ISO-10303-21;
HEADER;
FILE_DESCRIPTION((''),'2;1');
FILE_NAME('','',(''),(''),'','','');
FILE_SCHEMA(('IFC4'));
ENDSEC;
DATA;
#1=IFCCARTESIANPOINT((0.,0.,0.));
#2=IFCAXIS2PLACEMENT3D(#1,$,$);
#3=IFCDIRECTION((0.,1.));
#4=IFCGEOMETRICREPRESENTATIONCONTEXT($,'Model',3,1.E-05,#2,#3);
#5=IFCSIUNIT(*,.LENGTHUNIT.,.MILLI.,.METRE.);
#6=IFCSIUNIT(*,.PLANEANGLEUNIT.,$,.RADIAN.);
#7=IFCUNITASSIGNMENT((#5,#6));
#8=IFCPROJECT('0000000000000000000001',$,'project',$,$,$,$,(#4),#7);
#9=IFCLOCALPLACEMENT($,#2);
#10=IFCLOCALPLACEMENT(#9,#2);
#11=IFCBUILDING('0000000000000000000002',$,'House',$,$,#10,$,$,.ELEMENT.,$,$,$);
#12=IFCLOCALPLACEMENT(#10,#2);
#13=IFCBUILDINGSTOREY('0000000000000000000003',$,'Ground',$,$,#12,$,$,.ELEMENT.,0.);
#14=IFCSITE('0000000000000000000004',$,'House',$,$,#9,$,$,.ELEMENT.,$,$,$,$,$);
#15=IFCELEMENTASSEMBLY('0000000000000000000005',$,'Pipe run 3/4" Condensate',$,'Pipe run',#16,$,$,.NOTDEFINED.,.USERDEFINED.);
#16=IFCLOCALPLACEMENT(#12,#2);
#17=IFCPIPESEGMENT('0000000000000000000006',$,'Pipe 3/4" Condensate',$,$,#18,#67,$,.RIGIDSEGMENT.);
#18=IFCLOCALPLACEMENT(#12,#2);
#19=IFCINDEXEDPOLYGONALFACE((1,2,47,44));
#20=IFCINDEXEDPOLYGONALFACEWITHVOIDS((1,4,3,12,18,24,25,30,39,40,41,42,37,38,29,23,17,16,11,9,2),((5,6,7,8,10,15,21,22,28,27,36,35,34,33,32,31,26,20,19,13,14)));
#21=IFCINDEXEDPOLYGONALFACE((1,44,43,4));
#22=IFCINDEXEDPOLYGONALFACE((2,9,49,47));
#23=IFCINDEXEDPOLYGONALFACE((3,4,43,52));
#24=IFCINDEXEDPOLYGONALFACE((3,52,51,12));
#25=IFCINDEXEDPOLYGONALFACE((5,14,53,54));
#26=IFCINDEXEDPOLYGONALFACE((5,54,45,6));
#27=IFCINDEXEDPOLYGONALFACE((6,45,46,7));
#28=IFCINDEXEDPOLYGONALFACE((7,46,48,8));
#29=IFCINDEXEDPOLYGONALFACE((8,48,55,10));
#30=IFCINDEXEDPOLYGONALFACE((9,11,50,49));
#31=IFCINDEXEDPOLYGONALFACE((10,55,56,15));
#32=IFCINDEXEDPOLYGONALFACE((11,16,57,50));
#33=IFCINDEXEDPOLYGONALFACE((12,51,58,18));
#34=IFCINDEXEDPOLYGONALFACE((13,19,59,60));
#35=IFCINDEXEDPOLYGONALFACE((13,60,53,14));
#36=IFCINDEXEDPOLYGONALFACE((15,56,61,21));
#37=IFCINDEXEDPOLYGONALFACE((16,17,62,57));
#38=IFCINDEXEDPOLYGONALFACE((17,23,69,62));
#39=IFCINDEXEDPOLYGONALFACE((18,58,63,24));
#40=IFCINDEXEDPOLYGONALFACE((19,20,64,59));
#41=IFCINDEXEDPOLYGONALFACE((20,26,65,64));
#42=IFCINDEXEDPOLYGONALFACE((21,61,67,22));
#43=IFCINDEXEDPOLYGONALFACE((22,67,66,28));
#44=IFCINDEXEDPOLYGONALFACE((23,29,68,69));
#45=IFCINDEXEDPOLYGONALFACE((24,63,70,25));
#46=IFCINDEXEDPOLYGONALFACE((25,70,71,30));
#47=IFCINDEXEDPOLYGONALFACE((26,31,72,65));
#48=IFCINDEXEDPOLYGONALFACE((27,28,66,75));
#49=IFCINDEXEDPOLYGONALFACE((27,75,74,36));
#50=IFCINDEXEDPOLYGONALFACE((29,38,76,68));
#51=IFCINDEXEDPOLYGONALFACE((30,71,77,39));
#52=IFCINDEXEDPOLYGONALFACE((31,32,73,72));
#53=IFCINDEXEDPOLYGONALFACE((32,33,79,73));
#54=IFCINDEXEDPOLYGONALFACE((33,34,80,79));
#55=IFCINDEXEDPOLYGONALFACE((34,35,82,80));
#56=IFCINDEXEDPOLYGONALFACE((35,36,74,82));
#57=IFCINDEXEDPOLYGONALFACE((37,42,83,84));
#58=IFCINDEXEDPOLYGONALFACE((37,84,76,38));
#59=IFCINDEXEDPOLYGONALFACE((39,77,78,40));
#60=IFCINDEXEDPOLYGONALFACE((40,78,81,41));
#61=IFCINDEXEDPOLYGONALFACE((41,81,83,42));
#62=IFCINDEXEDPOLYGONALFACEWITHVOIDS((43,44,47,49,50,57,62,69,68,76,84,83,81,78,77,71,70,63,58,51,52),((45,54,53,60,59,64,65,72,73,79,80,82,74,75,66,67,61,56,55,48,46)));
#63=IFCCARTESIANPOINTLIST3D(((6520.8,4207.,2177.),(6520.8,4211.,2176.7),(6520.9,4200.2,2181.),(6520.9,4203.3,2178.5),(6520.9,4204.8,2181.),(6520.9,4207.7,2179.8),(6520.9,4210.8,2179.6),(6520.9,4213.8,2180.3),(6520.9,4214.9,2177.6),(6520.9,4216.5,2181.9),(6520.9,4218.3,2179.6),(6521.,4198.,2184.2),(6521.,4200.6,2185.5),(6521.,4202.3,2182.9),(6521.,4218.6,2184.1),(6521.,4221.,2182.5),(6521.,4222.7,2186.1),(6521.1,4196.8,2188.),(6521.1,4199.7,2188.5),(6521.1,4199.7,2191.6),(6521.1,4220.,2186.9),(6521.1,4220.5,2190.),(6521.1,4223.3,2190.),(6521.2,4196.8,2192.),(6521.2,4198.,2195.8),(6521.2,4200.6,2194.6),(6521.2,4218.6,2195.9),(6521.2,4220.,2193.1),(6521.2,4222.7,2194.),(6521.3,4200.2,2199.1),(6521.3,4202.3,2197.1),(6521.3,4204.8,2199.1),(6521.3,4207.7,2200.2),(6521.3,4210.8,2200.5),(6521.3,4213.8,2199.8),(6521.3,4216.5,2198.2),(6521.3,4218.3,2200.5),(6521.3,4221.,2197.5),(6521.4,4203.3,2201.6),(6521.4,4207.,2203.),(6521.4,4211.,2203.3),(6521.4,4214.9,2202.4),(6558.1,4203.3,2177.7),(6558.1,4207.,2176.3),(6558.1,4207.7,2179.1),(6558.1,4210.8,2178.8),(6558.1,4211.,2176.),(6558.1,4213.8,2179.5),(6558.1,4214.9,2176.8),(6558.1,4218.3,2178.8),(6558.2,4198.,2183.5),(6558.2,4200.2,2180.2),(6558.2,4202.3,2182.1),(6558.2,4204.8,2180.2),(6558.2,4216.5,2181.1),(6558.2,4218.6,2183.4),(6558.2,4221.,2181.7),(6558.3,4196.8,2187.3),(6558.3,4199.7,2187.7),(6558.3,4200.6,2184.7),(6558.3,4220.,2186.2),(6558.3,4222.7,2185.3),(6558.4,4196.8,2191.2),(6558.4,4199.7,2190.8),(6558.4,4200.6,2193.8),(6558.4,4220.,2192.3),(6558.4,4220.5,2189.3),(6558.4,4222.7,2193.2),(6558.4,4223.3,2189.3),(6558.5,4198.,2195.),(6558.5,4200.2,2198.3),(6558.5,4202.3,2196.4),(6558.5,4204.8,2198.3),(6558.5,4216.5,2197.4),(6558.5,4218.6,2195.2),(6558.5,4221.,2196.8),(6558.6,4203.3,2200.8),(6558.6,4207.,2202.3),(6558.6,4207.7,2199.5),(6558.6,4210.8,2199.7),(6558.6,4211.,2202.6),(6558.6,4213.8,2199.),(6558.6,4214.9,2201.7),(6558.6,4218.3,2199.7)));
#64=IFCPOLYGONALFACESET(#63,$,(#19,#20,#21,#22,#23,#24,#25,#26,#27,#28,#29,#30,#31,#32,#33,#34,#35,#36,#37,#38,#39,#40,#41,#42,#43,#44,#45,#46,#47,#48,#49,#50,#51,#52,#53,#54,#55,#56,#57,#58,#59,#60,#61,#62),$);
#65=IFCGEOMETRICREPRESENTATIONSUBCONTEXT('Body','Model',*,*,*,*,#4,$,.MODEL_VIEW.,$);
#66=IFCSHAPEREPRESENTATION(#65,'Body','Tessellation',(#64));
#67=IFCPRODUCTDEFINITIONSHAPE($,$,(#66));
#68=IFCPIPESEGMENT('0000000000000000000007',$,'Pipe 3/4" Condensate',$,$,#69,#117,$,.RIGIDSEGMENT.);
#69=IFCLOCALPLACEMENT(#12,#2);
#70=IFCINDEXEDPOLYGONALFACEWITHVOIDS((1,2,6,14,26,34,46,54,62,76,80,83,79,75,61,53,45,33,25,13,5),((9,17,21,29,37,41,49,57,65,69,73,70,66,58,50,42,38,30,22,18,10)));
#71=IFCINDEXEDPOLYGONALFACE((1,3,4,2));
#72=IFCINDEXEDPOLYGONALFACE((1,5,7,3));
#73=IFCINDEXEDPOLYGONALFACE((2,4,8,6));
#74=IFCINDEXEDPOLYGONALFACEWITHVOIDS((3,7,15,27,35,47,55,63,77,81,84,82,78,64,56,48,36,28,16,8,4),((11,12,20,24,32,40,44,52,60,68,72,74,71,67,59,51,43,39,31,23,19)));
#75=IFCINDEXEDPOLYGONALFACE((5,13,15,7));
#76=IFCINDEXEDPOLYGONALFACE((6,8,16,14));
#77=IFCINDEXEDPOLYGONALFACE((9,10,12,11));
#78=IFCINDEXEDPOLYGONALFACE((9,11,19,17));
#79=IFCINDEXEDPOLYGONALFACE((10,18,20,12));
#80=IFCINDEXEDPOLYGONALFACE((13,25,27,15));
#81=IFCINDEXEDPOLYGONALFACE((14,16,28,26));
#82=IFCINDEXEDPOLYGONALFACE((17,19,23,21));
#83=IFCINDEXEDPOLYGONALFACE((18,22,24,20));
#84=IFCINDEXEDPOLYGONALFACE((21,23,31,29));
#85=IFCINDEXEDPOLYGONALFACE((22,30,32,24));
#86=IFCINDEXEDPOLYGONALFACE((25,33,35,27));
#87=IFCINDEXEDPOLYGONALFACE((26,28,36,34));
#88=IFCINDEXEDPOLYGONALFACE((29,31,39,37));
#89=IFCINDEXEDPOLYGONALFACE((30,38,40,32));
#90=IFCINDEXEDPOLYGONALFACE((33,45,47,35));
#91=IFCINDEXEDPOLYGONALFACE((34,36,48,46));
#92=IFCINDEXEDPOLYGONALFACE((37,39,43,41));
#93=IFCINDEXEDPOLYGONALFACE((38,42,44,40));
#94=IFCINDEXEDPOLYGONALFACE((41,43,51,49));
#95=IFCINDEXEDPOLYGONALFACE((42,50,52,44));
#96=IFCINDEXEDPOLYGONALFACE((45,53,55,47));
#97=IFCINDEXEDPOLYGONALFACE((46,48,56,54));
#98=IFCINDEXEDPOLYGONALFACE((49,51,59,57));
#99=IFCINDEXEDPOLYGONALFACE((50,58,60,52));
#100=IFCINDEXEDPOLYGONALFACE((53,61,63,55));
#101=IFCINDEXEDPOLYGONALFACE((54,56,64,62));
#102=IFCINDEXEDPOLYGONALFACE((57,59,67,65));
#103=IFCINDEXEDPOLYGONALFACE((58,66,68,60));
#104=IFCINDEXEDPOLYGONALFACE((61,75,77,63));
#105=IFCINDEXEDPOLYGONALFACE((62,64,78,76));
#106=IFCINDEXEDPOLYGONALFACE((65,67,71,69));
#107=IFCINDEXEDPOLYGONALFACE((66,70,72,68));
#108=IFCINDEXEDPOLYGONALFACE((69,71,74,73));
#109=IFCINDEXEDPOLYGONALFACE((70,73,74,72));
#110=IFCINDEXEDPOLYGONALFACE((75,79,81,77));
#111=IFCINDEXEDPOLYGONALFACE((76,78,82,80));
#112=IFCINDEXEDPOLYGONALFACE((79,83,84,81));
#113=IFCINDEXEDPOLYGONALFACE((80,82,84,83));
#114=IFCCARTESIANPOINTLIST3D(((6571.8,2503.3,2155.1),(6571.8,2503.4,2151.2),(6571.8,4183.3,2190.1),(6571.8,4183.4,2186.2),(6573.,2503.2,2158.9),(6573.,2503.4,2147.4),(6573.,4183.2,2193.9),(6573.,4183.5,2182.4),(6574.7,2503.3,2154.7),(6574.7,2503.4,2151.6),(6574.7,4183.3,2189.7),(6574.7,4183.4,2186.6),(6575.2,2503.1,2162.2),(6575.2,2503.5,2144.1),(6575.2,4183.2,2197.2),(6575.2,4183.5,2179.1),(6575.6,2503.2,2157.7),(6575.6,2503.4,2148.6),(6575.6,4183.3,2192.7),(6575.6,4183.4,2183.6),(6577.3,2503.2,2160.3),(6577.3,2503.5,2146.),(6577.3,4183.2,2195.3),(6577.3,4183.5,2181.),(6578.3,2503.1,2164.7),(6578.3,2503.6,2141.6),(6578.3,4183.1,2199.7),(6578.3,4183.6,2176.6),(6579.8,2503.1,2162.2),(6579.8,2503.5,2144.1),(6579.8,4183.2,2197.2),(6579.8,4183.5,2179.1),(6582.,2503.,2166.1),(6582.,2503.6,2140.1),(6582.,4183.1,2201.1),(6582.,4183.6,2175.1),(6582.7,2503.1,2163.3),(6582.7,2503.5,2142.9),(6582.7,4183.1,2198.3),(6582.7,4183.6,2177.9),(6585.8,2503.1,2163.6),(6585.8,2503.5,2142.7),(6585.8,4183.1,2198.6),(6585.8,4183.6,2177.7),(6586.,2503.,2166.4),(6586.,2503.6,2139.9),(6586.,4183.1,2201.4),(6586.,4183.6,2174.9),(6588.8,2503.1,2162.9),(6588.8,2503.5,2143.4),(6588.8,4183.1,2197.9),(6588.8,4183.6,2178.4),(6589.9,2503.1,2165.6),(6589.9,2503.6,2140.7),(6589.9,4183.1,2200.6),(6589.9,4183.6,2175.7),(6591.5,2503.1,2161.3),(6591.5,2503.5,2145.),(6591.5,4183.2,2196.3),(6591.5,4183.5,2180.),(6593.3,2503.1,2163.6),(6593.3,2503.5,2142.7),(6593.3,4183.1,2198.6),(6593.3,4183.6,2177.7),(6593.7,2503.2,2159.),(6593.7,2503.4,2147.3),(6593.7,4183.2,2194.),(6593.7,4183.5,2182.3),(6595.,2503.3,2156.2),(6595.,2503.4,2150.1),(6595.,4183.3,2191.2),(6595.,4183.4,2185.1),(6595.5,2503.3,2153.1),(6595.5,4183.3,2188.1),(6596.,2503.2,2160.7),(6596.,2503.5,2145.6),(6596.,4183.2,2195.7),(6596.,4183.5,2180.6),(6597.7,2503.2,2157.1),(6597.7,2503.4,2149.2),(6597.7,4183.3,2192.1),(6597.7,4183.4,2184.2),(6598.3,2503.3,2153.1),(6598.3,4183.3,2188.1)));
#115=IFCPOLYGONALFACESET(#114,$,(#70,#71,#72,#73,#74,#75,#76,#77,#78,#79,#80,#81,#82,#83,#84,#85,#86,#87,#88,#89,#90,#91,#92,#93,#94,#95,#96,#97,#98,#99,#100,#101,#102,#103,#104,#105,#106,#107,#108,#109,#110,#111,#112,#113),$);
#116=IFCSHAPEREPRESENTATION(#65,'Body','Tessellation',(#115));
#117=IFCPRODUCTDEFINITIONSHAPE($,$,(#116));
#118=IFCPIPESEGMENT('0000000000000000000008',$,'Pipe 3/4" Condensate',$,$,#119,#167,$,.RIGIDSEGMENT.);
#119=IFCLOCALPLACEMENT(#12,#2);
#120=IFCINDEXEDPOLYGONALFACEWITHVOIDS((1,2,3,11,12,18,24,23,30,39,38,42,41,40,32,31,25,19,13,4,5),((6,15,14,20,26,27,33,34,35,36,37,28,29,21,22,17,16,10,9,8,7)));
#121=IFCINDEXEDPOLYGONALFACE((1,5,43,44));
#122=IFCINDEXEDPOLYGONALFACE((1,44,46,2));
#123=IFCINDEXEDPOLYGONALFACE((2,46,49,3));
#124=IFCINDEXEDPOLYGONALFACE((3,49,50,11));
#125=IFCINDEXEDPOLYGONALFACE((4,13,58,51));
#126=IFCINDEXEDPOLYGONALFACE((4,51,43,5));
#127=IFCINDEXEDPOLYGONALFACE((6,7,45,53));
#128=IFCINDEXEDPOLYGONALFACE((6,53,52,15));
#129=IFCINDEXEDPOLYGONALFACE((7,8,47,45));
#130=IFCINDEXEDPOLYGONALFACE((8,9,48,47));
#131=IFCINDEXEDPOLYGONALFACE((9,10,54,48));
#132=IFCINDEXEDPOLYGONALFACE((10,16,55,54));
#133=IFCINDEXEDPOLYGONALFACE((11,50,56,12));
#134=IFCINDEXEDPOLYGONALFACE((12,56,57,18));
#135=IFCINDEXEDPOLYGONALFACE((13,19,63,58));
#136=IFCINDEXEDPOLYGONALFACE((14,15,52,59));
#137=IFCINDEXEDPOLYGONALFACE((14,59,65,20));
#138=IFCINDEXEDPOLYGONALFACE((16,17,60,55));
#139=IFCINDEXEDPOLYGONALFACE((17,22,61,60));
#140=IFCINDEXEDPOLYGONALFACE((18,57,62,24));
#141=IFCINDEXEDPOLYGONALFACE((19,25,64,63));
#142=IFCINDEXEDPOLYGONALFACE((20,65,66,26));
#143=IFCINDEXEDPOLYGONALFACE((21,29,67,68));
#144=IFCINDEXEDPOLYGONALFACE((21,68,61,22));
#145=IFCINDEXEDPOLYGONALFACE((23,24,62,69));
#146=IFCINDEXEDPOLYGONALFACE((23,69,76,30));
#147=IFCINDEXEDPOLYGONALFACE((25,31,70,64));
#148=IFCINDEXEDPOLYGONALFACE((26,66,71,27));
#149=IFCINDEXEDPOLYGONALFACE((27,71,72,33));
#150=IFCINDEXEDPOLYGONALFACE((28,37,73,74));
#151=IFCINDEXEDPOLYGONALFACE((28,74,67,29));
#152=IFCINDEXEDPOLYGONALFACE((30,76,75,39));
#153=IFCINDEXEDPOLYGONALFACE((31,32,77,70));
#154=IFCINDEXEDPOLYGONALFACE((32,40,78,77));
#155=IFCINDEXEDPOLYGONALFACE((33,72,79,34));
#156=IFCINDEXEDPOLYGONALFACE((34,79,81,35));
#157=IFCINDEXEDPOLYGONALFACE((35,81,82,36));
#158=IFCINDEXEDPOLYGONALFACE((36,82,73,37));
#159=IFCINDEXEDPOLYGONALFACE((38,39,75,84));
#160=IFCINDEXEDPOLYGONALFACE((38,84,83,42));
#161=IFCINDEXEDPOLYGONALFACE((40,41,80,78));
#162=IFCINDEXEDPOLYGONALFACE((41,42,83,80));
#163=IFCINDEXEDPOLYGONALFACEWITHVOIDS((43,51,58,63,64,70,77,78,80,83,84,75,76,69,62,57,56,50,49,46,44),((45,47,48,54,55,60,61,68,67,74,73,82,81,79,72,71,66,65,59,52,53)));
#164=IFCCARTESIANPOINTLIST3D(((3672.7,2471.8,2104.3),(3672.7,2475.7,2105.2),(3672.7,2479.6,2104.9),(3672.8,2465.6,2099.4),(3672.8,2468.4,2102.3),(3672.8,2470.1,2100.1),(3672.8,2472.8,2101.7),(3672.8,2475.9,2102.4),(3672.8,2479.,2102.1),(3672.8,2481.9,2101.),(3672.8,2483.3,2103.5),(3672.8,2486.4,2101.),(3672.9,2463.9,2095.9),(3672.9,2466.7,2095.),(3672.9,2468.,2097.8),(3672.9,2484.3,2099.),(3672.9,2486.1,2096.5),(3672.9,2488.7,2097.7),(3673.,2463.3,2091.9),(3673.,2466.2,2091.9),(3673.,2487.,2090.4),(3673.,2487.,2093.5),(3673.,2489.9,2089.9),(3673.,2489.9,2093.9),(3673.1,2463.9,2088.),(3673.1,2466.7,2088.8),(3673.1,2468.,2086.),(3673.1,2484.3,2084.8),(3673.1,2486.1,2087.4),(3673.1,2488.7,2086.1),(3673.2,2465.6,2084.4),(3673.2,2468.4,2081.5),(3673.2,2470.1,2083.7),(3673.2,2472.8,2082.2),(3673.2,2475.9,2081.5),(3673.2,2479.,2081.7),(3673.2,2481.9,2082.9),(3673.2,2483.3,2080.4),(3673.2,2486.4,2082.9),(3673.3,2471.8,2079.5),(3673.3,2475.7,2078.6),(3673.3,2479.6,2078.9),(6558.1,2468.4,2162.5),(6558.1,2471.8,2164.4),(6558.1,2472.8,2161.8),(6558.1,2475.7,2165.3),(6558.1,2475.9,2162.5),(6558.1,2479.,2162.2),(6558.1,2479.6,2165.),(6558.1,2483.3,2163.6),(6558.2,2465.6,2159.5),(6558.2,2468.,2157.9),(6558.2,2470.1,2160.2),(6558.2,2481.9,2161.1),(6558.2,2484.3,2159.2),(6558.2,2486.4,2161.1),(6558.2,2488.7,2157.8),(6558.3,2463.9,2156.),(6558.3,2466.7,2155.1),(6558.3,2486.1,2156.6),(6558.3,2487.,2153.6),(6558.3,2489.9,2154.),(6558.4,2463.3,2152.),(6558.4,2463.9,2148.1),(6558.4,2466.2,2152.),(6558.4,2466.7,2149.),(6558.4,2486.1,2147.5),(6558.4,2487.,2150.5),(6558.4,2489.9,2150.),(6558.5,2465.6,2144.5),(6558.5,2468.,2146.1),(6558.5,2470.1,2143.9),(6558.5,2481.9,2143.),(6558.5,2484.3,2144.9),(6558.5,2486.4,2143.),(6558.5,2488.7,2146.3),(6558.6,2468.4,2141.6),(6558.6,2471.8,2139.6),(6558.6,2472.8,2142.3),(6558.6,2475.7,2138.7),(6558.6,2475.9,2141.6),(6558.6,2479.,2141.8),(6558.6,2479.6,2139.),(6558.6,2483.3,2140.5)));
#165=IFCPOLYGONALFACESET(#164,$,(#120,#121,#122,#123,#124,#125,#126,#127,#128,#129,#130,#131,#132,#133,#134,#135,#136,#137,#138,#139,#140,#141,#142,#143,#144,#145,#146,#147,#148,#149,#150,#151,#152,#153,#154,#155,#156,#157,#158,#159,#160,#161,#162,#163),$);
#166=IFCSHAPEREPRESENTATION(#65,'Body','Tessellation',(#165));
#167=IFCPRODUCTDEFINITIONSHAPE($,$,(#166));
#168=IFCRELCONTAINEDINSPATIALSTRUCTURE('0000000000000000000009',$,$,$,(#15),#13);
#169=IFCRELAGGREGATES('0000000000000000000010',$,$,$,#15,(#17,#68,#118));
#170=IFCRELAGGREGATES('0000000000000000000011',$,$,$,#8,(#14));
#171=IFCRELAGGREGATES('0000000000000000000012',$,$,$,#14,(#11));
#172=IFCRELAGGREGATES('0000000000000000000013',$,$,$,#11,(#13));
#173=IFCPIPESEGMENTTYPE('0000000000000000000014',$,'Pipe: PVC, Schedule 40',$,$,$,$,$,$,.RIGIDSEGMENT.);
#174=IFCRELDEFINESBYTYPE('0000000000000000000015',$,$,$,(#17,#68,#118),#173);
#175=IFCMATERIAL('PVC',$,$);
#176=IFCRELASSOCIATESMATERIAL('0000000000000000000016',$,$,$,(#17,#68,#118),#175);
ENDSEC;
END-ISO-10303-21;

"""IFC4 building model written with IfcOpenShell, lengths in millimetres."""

from ifc_helpers import new_model, si_unit, direction, frame, origin, origin_with_axes, origin_2d, place, context, subcontext, project, spatial, hollow_circle, extrude, material, type_object, element, aggregate, save


model = new_model("IFC4")

# Units and contexts
model_context = context("Model", 3, precision=1e-05, world=origin(), true_north=direction((0.0, 1.0)))
body_context = subcontext(model_context, "Body", "Model", "MODEL_VIEW")
ifc_project = project(units=[si_unit("LENGTHUNIT", "METRE", prefix="MILLI"), si_unit("PLANEANGLEUNIT", "RADIAN")], contexts=[model_context])

# Site, building, storey
site_placement = place(None, origin())
site = spatial("IfcSite", under=ifc_project, at=site_placement, Name="House", CompositionType="ELEMENT")
building_placement = place(site_placement, origin())
building = spatial("IfcBuilding", under=site, at=building_placement, Name="House", CompositionType="ELEMENT")
storey_placement = place(building_placement, origin())
storey = spatial("IfcBuildingStorey", under=building, at=storey_placement, Name="Ground", CompositionType="ELEMENT", Elevation=0.0)

# Element assembly
ifc_material_1 = material(Name="PVC")
assembly_1_placement = place(storey_placement, origin_with_axes())
assembly_1 = element("IfcElementAssembly", 1, at=assembly_1_placement, inside=storey, Name="Pipe run 3/4\" Condensate", ObjectType="Pipe run", AssemblyPlace="NOTDEFINED", PredefinedType="USERDEFINED")

# Pipe segments
pipe_segment_type_1 = type_object("IfcPipeSegmentType", Name="Pipe: PVC, Schedule 40", PredefinedType="RIGIDSEGMENT")
pipe_segment_1_placement = place(storey_placement, origin_with_axes())
pipe_segment_1 = element("IfcPipeSegment", 2, at=pipe_segment_1_placement, type_object=pipe_segment_type_1, material=ifc_material_1, Name="Pipe 3/4\" Condensate", PredefinedType="RIGIDSEGMENT", context=body_context, shape_type="SweptSolid", body=[
    extrude(hollow_circle(Radius=13.3, WallThickness=2.9, at=origin_2d()), frame((6521.1, 4210.0, 2190.0), z_axis=(0.999783, 0.0, -0.020829), x_axis=(0.0, 1.0, 0.0)), (0.0, 0.0, 1.0), 37.2),
])
pipe_segment_2_placement = place(storey_placement, origin_with_axes())
pipe_segment_2 = element("IfcPipeSegment", 3, at=pipe_segment_2_placement, type_object=pipe_segment_type_1, material=ifc_material_1, Name="Pipe 3/4\" Condensate", PredefinedType="RIGIDSEGMENT", context=body_context, shape_type="SweptSolid", body=[
    extrude(hollow_circle(Radius=13.3, WallThickness=2.9, at=origin_2d()), frame((6585.0, 4183.3, 2188.1), z_axis=(0.0, -0.999783, -0.020829), x_axis=(1.0, 0.0, 0.0)), (0.0, 0.0, 1.0), 1680.4),
])
pipe_segment_3_placement = place(storey_placement, origin_with_axes())
pipe_segment_3 = element("IfcPipeSegment", 4, at=pipe_segment_3_placement, type_object=pipe_segment_type_1, material=ifc_material_1, Name="Pipe 3/4\" Condensate", PredefinedType="RIGIDSEGMENT", context=body_context, shape_type="SweptSolid", body=[
    extrude(hollow_circle(Radius=13.3, WallThickness=2.9, at=origin_2d()), frame((6558.4, 2476.7, 2152.0), z_axis=(-0.999783, 0.0, -0.020829), x_axis=(0.0, -1.0, 0.0)), (0.0, 0.0, 1.0), 2886.0),
])
aggregate(assembly_1, [pipe_segment_1, pipe_segment_2, pipe_segment_3])

save(model, "model.ifc")
